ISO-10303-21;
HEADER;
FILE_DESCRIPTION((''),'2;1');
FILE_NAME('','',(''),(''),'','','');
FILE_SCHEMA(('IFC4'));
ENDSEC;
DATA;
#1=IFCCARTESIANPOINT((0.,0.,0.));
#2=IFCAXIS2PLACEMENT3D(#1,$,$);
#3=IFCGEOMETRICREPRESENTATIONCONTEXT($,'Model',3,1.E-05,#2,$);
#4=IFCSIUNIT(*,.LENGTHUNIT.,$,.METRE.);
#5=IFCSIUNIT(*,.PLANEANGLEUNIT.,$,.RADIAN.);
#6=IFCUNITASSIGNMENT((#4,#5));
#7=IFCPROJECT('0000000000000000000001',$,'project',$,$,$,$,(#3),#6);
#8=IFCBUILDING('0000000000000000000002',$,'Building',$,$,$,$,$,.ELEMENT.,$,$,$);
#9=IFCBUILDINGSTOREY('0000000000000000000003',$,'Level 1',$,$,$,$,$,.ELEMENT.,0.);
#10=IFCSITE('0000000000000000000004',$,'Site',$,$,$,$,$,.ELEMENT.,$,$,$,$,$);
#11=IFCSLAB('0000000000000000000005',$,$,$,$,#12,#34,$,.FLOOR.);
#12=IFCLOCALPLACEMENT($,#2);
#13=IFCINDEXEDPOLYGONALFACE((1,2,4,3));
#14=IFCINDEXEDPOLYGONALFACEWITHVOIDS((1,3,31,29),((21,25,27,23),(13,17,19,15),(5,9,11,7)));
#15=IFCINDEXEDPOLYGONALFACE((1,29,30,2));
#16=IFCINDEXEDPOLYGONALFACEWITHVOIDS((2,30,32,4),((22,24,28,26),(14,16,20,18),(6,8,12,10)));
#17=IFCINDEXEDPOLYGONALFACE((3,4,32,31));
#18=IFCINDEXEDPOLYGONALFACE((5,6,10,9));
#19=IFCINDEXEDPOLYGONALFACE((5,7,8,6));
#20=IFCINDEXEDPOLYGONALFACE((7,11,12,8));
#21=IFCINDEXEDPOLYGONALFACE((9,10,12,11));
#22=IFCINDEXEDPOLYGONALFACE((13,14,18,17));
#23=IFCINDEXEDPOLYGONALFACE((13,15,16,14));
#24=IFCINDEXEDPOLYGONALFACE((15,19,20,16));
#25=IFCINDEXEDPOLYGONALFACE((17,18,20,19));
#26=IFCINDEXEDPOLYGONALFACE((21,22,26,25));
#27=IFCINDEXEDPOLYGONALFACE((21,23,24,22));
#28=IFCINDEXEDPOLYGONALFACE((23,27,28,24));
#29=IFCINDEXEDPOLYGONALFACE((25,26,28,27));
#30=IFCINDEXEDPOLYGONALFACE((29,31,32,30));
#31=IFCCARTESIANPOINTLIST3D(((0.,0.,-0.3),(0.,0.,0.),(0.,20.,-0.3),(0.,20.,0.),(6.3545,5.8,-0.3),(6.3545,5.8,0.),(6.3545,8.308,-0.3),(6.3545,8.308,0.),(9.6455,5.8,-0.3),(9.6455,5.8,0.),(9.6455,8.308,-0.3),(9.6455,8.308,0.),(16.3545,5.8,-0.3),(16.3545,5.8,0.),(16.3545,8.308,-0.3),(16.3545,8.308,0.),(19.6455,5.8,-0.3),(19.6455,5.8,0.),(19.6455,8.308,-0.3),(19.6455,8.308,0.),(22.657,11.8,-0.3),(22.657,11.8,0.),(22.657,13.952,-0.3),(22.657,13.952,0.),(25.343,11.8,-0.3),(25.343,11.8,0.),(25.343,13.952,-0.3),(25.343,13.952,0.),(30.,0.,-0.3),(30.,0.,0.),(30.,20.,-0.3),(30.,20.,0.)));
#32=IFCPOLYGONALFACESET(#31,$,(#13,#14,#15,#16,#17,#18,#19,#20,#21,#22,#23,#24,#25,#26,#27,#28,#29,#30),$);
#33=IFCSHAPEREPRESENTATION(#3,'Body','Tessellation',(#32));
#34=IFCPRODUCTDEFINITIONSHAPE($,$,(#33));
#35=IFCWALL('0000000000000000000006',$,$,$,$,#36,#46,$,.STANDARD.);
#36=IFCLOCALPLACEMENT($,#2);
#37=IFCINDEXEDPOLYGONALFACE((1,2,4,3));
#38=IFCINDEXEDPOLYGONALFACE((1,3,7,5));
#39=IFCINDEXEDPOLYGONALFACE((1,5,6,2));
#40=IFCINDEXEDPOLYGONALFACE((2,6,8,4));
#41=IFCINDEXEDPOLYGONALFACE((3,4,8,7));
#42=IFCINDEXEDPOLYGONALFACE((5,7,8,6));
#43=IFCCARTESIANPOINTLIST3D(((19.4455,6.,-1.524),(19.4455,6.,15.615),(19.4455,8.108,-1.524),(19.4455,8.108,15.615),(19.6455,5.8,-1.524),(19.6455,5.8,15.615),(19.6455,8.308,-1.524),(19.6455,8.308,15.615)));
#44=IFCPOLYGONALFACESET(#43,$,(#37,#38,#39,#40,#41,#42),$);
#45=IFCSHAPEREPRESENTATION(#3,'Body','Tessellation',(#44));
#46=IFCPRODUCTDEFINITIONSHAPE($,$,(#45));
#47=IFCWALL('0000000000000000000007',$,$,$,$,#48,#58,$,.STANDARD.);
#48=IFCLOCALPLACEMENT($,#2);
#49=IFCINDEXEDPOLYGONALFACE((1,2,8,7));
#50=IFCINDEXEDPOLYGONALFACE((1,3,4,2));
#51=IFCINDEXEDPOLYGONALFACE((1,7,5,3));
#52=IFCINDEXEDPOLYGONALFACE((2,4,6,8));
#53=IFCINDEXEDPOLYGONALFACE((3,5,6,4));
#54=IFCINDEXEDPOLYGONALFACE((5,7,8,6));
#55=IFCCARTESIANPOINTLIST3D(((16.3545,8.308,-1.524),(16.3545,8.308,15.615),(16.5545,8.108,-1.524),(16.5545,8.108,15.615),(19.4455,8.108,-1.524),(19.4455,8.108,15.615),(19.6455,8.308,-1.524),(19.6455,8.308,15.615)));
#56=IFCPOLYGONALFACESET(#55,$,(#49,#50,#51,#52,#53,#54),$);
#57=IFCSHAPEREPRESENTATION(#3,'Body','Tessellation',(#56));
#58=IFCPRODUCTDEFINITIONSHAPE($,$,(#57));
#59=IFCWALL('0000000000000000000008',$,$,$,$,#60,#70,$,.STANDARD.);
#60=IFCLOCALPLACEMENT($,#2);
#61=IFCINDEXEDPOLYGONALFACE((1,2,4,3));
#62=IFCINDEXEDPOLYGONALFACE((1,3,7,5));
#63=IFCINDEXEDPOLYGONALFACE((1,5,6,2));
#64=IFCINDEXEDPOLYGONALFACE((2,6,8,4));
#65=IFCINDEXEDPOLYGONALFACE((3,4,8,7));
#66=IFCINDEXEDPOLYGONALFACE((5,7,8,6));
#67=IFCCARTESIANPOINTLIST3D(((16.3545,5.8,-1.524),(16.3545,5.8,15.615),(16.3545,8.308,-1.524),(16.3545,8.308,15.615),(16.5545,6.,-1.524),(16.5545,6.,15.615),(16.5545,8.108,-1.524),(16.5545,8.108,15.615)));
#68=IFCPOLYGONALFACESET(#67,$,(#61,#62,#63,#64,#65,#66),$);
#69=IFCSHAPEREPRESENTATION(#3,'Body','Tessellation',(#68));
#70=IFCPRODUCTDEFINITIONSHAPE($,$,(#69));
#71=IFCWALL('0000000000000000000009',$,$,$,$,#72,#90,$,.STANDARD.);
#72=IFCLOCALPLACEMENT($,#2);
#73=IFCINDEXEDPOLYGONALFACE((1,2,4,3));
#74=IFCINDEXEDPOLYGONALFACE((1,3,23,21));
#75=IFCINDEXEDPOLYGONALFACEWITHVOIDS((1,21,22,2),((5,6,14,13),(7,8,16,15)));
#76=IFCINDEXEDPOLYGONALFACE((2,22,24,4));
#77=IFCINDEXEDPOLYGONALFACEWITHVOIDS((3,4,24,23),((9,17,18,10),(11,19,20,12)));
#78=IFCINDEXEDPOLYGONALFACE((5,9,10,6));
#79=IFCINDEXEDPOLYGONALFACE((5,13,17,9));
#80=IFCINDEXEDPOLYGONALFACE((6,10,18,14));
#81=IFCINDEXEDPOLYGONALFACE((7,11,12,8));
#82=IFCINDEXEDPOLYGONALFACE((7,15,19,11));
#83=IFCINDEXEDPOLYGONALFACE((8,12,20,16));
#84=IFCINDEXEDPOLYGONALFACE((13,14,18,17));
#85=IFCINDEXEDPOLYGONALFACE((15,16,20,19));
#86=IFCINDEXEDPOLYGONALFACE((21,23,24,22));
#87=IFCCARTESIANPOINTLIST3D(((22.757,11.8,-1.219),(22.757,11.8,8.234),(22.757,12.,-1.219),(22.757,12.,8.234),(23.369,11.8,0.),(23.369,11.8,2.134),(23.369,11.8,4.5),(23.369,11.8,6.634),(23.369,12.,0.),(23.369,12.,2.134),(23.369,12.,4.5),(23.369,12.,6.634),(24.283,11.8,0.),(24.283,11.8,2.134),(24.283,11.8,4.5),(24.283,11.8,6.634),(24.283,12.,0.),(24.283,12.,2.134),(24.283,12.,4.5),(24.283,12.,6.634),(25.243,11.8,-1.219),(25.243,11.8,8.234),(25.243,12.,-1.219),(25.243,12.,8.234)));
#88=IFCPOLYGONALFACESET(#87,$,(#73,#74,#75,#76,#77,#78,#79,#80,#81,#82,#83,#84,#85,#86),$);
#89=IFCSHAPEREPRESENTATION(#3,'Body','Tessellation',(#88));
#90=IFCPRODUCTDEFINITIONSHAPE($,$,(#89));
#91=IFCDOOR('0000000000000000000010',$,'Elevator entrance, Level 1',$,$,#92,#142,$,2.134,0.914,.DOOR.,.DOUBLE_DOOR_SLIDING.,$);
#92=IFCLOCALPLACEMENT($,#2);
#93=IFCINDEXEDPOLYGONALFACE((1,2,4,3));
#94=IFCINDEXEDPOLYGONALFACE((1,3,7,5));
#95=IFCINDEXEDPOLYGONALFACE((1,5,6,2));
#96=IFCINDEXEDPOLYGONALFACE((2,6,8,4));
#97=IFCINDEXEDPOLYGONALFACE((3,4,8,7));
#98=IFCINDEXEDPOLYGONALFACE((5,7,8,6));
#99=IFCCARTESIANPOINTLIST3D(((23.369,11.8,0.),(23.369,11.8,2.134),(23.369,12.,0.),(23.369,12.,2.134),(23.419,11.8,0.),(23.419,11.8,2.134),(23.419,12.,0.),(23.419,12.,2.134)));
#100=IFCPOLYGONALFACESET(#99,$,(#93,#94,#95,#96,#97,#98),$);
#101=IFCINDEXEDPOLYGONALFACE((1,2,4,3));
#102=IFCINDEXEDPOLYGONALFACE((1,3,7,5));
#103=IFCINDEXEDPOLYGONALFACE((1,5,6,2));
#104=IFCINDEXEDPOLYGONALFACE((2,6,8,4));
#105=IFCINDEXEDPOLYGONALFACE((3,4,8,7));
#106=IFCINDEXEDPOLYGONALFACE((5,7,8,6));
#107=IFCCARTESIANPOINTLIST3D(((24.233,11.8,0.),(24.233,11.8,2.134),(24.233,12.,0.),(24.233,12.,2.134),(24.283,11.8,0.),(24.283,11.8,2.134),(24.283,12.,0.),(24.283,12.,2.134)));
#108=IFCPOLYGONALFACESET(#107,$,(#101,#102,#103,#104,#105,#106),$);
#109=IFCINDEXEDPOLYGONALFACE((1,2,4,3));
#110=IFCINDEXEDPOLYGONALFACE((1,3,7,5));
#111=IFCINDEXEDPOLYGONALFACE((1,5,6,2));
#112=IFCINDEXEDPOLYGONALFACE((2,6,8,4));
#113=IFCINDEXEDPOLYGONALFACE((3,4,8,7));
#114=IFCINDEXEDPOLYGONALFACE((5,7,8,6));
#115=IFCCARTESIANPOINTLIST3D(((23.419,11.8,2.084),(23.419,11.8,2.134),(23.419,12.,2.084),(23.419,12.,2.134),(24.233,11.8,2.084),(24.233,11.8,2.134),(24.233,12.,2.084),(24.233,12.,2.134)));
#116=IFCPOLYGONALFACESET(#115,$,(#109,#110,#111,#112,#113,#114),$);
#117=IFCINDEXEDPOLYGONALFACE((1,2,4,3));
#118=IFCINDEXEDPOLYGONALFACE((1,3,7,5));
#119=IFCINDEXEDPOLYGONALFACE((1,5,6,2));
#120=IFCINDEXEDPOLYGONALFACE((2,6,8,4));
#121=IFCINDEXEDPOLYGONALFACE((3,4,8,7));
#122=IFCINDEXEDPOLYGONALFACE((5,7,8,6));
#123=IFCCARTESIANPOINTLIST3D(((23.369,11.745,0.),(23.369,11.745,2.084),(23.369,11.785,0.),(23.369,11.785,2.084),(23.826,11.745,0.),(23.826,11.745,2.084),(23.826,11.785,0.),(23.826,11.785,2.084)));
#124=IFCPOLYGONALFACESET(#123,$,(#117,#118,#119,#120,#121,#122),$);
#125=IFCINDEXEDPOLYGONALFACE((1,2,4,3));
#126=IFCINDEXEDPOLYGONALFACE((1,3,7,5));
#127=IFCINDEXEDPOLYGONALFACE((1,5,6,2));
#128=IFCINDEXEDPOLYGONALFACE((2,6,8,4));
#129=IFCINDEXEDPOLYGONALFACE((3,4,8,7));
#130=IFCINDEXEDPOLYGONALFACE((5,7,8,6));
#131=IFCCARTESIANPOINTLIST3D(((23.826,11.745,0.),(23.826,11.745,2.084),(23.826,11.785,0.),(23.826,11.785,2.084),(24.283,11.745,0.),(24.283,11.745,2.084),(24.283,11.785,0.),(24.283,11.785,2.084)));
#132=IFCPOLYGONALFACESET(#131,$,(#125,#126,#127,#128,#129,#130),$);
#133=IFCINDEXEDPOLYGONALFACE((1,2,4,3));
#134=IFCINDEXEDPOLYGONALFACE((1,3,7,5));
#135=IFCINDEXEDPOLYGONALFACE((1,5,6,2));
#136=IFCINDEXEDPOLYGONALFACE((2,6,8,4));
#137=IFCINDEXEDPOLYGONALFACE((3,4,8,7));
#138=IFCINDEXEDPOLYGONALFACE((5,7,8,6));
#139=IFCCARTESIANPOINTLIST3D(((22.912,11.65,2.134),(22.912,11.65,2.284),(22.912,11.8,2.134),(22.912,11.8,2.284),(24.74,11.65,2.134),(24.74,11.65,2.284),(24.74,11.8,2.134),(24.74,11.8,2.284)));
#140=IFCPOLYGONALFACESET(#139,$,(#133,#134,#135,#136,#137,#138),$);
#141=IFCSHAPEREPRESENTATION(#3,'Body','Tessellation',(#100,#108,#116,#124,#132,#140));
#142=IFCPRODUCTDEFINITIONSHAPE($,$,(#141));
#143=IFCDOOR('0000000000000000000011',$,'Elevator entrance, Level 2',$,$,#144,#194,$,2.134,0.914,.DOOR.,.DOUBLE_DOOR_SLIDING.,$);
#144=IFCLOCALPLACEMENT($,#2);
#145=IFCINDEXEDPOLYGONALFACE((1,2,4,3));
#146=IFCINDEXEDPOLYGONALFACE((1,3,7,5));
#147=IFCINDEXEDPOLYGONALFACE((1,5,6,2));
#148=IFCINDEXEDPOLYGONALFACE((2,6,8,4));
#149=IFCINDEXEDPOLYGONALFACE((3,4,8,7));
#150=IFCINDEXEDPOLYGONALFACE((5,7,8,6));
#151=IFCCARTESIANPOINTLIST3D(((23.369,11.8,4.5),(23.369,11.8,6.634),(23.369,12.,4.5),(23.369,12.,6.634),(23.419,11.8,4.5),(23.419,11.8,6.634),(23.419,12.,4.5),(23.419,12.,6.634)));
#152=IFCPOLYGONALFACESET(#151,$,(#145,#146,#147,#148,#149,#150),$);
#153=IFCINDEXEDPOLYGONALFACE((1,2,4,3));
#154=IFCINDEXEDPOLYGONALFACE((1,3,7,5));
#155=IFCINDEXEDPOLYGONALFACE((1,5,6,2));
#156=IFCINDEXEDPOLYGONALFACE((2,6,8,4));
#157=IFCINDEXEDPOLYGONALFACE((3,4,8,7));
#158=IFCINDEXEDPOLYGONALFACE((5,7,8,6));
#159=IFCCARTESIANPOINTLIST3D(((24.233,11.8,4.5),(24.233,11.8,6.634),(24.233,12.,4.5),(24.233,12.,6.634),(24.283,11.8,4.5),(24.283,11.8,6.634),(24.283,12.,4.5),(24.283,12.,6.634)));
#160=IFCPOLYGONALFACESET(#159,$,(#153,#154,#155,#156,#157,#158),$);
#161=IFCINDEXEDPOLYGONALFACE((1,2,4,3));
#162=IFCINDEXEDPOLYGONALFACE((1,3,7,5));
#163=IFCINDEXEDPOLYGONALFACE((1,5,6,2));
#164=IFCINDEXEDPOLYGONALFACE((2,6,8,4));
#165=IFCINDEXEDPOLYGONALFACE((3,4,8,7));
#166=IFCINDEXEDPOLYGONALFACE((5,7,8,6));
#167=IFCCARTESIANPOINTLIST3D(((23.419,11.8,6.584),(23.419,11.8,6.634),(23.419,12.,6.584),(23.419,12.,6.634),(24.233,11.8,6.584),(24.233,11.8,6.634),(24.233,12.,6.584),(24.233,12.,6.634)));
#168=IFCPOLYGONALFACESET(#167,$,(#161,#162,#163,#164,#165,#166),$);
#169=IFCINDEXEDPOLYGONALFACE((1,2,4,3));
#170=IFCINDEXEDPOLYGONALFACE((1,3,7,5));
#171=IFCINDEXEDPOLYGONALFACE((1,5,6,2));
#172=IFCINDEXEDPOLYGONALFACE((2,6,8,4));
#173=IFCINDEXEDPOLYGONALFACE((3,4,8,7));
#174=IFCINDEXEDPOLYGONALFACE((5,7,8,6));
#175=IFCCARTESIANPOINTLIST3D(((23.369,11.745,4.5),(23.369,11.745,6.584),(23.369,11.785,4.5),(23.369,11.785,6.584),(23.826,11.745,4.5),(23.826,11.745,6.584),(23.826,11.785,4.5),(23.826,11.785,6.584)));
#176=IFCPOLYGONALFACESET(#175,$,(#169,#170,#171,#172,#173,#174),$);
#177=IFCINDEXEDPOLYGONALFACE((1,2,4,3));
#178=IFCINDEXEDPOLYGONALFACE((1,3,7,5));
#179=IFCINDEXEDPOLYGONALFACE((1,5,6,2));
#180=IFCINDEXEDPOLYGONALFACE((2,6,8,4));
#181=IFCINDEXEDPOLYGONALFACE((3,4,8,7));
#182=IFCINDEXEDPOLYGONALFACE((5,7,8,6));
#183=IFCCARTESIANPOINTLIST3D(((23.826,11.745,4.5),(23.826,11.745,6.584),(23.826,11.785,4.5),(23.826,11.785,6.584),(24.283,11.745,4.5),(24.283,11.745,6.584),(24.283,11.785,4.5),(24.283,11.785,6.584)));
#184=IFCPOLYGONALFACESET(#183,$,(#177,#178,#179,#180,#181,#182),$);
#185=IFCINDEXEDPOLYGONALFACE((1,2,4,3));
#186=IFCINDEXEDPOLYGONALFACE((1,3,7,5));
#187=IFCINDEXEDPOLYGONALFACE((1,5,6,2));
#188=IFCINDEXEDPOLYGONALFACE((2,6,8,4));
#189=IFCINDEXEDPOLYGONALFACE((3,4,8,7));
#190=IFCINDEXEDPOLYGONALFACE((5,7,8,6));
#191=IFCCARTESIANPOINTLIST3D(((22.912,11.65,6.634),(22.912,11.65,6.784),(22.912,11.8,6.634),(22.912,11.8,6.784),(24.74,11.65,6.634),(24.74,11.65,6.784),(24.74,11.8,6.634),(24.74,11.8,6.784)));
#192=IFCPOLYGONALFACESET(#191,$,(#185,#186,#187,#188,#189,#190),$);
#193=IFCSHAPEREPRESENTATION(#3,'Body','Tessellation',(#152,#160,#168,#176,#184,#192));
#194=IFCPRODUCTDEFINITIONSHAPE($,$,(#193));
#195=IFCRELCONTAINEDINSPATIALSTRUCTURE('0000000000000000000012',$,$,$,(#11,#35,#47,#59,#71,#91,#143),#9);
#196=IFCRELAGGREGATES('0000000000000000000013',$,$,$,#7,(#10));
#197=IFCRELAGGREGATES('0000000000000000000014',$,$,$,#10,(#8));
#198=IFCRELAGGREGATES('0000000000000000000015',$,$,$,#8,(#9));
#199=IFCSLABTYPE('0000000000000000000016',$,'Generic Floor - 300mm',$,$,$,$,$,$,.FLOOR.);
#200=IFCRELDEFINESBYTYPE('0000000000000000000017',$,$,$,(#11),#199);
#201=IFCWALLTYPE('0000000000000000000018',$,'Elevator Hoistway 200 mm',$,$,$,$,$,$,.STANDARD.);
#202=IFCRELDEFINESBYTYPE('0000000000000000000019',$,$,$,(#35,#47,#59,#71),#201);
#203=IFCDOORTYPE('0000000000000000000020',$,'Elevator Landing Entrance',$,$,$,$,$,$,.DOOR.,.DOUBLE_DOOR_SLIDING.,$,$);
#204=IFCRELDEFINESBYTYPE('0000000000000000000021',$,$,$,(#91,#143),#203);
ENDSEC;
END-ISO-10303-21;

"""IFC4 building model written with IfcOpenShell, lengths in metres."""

from ifc_helpers import new_model, si_unit, frame, frame_2d, origin, origin_with_axes, origin_2d, place, context, project, spatial, polyline, rectangle, outline, extrude, type_object, element, fill, save


model = new_model("IFC4")

# Units and contexts
model_context = context("Model", 3, precision=1e-05, world=origin())
ifc_project = project(units=[si_unit("LENGTHUNIT", "METRE"), si_unit("PLANEANGLEUNIT", "RADIAN")], contexts=[model_context])

# Site, building, storey
site = spatial("IfcSite", under=ifc_project, Name="Site", CompositionType="ELEMENT")
building = spatial("IfcBuilding", under=site, Name="Building", CompositionType="ELEMENT")
storey = spatial("IfcBuildingStorey", under=building, Name="Level 1", CompositionType="ELEMENT", Elevation=0.0)

# Slab, openings
slab_type = type_object("IfcSlabType", Name="Generic Floor - 300mm", PredefinedType="FLOOR")
slab_placement = place(None, origin())
slab = element("IfcSlab", 1, at=slab_placement, inside=storey, type_object=slab_type, PredefinedType="FLOOR", context=model_context, shape_type="SweptSolid", body=[
    extrude(outline(polyline([(0.0, 0.0), (30.0, 0.0), (30.0, 20.0), (0.0, 20.0), (0.0, 0.0)])), origin(), (0.0, 0.0, -1.0), 0.3),
])
opening_1_placement = place(None, frame((0.0, 0.0, 0.001)))
element("IfcOpeningElement", 2, at=opening_1_placement, cuts=slab, PredefinedType="OPENING", context=model_context, shape_type="SweptSolid", body=[
    extrude(outline(polyline([(6.3545, 5.8), (9.6455, 5.8), (9.6455, 8.308), (6.3545, 8.308), (6.3545, 5.8)])), origin(), (0.0, 0.0, -1.0), 0.302),
])
opening_2_placement = place(None, frame((0.0, 0.0, 0.001)))
element("IfcOpeningElement", 3, at=opening_2_placement, cuts=slab, PredefinedType="OPENING", context=model_context, shape_type="SweptSolid", body=[
    extrude(outline(polyline([(16.3545, 5.8), (19.6455, 5.8), (19.6455, 8.308), (16.3545, 8.308), (16.3545, 5.8)])), origin(), (0.0, 0.0, -1.0), 0.302),
])
opening_3_placement = place(None, frame((0.0, 0.0, 0.001)))
element("IfcOpeningElement", 4, at=opening_3_placement, cuts=slab, PredefinedType="OPENING", context=model_context, shape_type="SweptSolid", body=[
    extrude(outline(polyline([(22.657, 11.8), (25.343, 11.8), (25.343, 13.952), (22.657, 13.952), (22.657, 11.8)])), origin(), (0.0, 0.0, -1.0), 0.302),
])

# Shared definitions
wall_type = type_object("IfcWallType", Name="Elevator Hoistway 200 mm", PredefinedType="STANDARD")
door_type = type_object("IfcDoorType", Name="Elevator Landing Entrance", OperationType="DOUBLE_DOOR_SLIDING", PredefinedType="DOOR")

# Walls
wall_1_placement = place(None, frame((19.5455, 5.9, -1.524), z_axis=(0.0, 0.0, 1.0), x_axis=(0.0, 1.0, 0.0)))
element("IfcWall", 5, at=wall_1_placement, inside=storey, type_object=wall_type, PredefinedType="STANDARD", context=model_context, shape_type="SweptSolid", body=[
    extrude(outline(polyline([(-0.1, -0.1), (2.408, -0.1), (2.208, 0.1), (0.1, 0.1), (-0.1, -0.1)])), origin(), (0.0, 0.0, 1.0), 17.139),
])
wall_2_placement = place(None, frame((19.5455, 8.208, -1.524), z_axis=(0.0, 0.0, 1.0), x_axis=(-1.0, 0.0, 0.0)))
element("IfcWall", 6, at=wall_2_placement, inside=storey, type_object=wall_type, PredefinedType="STANDARD", context=model_context, shape_type="SweptSolid", body=[
    extrude(outline(polyline([(-0.1, -0.1), (3.191, -0.1), (2.991, 0.1), (0.1, 0.1), (-0.1, -0.1)])), origin(), (0.0, 0.0, 1.0), 17.139),
])
wall_3_placement = place(None, frame((16.4545, 8.208, -1.524), z_axis=(0.0, 0.0, 1.0), x_axis=(0.0, -1.0, 0.0)))
element("IfcWall", 7, at=wall_3_placement, inside=storey, type_object=wall_type, PredefinedType="STANDARD", context=model_context, shape_type="SweptSolid", body=[
    extrude(outline(polyline([(-0.1, -0.1), (2.408, -0.1), (2.208, 0.1), (0.1, 0.1), (-0.1, -0.1)])), origin(), (0.0, 0.0, 1.0), 17.139),
])

# Wall, openings, doors
wall_4_placement = place(None, frame((22.757, 11.9, -1.219), z_axis=(0.0, 0.0, 1.0), x_axis=(1.0, 0.0, 0.0)))
wall_4 = element("IfcWall", 8, at=wall_4_placement, inside=storey, type_object=wall_type, PredefinedType="STANDARD", context=model_context, shape_type="SweptSolid", body=[
    extrude(rectangle(XDim=2.486, YDim=0.2, at=frame_2d((1.243, 0.0))), origin(), (0.0, 0.0, 1.0), 9.453),
])
opening_4_placement = place(wall_4_placement, frame((1.069, 0.0, 1.219), z_axis=(0.0, 0.0, 1.0), x_axis=(1.0, 0.0, 0.0)))
opening_4 = element("IfcOpeningElement", 9, at=opening_4_placement, cuts=wall_4, PredefinedType="OPENING", context=model_context, shape_type="SweptSolid", body=[
    extrude(rectangle(XDim=0.914, YDim=0.202, at=origin_2d()), origin(), (0.0, 0.0, 1.0), 2.134),
])
opening_5_placement = place(wall_4_placement, frame((1.069, 0.0, 5.719), z_axis=(0.0, 0.0, 1.0), x_axis=(1.0, 0.0, 0.0)))
opening_5 = element("IfcOpeningElement", 10, at=opening_5_placement, cuts=wall_4, PredefinedType="OPENING", context=model_context, shape_type="SweptSolid", body=[
    extrude(rectangle(XDim=0.914, YDim=0.202, at=origin_2d()), origin(), (0.0, 0.0, 1.0), 2.134),
])
door_1_placement = place(opening_4_placement, origin_with_axes())
door_1 = element("IfcDoor", 11, at=door_1_placement, inside=storey, type_object=door_type, Name="Elevator entrance, Level 1", OperationType="DOUBLE_DOOR_SLIDING", OverallHeight=2.134, OverallWidth=0.914, PredefinedType="DOOR", context=model_context, shape_type="SweptSolid", body=[
    extrude(rectangle(XDim=0.05, YDim=0.2, at=frame_2d((-0.432, 0.0))), origin(), (0.0, 0.0, 1.0), 2.134),
    extrude(rectangle(XDim=0.05, YDim=0.2, at=frame_2d((0.432, 0.0))), origin(), (0.0, 0.0, 1.0), 2.134),
    extrude(rectangle(XDim=0.814, YDim=0.2, at=origin_2d()), frame((0.0, 0.0, 2.084)), (0.0, 0.0, 1.0), 0.05),
    extrude(rectangle(XDim=0.457, YDim=0.04, at=frame_2d((-0.2285, -0.135))), origin(), (0.0, 0.0, 1.0), 2.084),
    extrude(rectangle(XDim=0.457, YDim=0.04, at=frame_2d((0.2285, -0.135))), origin(), (0.0, 0.0, 1.0), 2.084),
    extrude(rectangle(XDim=1.828, YDim=0.15, at=frame_2d((0.0, -0.175))), frame((0.0, 0.0, 2.134)), (0.0, 0.0, 1.0), 0.15),
])
fill(opening_4, door_1)
door_2_placement = place(opening_5_placement, origin_with_axes())
door_2 = element("IfcDoor", 12, at=door_2_placement, inside=storey, type_object=door_type, Name="Elevator entrance, Level 2", OperationType="DOUBLE_DOOR_SLIDING", OverallHeight=2.134, OverallWidth=0.914, PredefinedType="DOOR", context=model_context, shape_type="SweptSolid", body=[
    extrude(rectangle(XDim=0.05, YDim=0.2, at=frame_2d((-0.432, 0.0))), origin(), (0.0, 0.0, 1.0), 2.134),
    extrude(rectangle(XDim=0.05, YDim=0.2, at=frame_2d((0.432, 0.0))), origin(), (0.0, 0.0, 1.0), 2.134),
    extrude(rectangle(XDim=0.814, YDim=0.2, at=origin_2d()), frame((0.0, 0.0, 2.084)), (0.0, 0.0, 1.0), 0.05),
    extrude(rectangle(XDim=0.457, YDim=0.04, at=frame_2d((-0.2285, -0.135))), origin(), (0.0, 0.0, 1.0), 2.084),
    extrude(rectangle(XDim=0.457, YDim=0.04, at=frame_2d((0.2285, -0.135))), origin(), (0.0, 0.0, 1.0), 2.084),
    extrude(rectangle(XDim=1.828, YDim=0.15, at=frame_2d((0.0, -0.175))), frame((0.0, 0.0, 2.134)), (0.0, 0.0, 1.0), 0.15),
])
fill(opening_5, door_2)

save(model, "model.ifc")
